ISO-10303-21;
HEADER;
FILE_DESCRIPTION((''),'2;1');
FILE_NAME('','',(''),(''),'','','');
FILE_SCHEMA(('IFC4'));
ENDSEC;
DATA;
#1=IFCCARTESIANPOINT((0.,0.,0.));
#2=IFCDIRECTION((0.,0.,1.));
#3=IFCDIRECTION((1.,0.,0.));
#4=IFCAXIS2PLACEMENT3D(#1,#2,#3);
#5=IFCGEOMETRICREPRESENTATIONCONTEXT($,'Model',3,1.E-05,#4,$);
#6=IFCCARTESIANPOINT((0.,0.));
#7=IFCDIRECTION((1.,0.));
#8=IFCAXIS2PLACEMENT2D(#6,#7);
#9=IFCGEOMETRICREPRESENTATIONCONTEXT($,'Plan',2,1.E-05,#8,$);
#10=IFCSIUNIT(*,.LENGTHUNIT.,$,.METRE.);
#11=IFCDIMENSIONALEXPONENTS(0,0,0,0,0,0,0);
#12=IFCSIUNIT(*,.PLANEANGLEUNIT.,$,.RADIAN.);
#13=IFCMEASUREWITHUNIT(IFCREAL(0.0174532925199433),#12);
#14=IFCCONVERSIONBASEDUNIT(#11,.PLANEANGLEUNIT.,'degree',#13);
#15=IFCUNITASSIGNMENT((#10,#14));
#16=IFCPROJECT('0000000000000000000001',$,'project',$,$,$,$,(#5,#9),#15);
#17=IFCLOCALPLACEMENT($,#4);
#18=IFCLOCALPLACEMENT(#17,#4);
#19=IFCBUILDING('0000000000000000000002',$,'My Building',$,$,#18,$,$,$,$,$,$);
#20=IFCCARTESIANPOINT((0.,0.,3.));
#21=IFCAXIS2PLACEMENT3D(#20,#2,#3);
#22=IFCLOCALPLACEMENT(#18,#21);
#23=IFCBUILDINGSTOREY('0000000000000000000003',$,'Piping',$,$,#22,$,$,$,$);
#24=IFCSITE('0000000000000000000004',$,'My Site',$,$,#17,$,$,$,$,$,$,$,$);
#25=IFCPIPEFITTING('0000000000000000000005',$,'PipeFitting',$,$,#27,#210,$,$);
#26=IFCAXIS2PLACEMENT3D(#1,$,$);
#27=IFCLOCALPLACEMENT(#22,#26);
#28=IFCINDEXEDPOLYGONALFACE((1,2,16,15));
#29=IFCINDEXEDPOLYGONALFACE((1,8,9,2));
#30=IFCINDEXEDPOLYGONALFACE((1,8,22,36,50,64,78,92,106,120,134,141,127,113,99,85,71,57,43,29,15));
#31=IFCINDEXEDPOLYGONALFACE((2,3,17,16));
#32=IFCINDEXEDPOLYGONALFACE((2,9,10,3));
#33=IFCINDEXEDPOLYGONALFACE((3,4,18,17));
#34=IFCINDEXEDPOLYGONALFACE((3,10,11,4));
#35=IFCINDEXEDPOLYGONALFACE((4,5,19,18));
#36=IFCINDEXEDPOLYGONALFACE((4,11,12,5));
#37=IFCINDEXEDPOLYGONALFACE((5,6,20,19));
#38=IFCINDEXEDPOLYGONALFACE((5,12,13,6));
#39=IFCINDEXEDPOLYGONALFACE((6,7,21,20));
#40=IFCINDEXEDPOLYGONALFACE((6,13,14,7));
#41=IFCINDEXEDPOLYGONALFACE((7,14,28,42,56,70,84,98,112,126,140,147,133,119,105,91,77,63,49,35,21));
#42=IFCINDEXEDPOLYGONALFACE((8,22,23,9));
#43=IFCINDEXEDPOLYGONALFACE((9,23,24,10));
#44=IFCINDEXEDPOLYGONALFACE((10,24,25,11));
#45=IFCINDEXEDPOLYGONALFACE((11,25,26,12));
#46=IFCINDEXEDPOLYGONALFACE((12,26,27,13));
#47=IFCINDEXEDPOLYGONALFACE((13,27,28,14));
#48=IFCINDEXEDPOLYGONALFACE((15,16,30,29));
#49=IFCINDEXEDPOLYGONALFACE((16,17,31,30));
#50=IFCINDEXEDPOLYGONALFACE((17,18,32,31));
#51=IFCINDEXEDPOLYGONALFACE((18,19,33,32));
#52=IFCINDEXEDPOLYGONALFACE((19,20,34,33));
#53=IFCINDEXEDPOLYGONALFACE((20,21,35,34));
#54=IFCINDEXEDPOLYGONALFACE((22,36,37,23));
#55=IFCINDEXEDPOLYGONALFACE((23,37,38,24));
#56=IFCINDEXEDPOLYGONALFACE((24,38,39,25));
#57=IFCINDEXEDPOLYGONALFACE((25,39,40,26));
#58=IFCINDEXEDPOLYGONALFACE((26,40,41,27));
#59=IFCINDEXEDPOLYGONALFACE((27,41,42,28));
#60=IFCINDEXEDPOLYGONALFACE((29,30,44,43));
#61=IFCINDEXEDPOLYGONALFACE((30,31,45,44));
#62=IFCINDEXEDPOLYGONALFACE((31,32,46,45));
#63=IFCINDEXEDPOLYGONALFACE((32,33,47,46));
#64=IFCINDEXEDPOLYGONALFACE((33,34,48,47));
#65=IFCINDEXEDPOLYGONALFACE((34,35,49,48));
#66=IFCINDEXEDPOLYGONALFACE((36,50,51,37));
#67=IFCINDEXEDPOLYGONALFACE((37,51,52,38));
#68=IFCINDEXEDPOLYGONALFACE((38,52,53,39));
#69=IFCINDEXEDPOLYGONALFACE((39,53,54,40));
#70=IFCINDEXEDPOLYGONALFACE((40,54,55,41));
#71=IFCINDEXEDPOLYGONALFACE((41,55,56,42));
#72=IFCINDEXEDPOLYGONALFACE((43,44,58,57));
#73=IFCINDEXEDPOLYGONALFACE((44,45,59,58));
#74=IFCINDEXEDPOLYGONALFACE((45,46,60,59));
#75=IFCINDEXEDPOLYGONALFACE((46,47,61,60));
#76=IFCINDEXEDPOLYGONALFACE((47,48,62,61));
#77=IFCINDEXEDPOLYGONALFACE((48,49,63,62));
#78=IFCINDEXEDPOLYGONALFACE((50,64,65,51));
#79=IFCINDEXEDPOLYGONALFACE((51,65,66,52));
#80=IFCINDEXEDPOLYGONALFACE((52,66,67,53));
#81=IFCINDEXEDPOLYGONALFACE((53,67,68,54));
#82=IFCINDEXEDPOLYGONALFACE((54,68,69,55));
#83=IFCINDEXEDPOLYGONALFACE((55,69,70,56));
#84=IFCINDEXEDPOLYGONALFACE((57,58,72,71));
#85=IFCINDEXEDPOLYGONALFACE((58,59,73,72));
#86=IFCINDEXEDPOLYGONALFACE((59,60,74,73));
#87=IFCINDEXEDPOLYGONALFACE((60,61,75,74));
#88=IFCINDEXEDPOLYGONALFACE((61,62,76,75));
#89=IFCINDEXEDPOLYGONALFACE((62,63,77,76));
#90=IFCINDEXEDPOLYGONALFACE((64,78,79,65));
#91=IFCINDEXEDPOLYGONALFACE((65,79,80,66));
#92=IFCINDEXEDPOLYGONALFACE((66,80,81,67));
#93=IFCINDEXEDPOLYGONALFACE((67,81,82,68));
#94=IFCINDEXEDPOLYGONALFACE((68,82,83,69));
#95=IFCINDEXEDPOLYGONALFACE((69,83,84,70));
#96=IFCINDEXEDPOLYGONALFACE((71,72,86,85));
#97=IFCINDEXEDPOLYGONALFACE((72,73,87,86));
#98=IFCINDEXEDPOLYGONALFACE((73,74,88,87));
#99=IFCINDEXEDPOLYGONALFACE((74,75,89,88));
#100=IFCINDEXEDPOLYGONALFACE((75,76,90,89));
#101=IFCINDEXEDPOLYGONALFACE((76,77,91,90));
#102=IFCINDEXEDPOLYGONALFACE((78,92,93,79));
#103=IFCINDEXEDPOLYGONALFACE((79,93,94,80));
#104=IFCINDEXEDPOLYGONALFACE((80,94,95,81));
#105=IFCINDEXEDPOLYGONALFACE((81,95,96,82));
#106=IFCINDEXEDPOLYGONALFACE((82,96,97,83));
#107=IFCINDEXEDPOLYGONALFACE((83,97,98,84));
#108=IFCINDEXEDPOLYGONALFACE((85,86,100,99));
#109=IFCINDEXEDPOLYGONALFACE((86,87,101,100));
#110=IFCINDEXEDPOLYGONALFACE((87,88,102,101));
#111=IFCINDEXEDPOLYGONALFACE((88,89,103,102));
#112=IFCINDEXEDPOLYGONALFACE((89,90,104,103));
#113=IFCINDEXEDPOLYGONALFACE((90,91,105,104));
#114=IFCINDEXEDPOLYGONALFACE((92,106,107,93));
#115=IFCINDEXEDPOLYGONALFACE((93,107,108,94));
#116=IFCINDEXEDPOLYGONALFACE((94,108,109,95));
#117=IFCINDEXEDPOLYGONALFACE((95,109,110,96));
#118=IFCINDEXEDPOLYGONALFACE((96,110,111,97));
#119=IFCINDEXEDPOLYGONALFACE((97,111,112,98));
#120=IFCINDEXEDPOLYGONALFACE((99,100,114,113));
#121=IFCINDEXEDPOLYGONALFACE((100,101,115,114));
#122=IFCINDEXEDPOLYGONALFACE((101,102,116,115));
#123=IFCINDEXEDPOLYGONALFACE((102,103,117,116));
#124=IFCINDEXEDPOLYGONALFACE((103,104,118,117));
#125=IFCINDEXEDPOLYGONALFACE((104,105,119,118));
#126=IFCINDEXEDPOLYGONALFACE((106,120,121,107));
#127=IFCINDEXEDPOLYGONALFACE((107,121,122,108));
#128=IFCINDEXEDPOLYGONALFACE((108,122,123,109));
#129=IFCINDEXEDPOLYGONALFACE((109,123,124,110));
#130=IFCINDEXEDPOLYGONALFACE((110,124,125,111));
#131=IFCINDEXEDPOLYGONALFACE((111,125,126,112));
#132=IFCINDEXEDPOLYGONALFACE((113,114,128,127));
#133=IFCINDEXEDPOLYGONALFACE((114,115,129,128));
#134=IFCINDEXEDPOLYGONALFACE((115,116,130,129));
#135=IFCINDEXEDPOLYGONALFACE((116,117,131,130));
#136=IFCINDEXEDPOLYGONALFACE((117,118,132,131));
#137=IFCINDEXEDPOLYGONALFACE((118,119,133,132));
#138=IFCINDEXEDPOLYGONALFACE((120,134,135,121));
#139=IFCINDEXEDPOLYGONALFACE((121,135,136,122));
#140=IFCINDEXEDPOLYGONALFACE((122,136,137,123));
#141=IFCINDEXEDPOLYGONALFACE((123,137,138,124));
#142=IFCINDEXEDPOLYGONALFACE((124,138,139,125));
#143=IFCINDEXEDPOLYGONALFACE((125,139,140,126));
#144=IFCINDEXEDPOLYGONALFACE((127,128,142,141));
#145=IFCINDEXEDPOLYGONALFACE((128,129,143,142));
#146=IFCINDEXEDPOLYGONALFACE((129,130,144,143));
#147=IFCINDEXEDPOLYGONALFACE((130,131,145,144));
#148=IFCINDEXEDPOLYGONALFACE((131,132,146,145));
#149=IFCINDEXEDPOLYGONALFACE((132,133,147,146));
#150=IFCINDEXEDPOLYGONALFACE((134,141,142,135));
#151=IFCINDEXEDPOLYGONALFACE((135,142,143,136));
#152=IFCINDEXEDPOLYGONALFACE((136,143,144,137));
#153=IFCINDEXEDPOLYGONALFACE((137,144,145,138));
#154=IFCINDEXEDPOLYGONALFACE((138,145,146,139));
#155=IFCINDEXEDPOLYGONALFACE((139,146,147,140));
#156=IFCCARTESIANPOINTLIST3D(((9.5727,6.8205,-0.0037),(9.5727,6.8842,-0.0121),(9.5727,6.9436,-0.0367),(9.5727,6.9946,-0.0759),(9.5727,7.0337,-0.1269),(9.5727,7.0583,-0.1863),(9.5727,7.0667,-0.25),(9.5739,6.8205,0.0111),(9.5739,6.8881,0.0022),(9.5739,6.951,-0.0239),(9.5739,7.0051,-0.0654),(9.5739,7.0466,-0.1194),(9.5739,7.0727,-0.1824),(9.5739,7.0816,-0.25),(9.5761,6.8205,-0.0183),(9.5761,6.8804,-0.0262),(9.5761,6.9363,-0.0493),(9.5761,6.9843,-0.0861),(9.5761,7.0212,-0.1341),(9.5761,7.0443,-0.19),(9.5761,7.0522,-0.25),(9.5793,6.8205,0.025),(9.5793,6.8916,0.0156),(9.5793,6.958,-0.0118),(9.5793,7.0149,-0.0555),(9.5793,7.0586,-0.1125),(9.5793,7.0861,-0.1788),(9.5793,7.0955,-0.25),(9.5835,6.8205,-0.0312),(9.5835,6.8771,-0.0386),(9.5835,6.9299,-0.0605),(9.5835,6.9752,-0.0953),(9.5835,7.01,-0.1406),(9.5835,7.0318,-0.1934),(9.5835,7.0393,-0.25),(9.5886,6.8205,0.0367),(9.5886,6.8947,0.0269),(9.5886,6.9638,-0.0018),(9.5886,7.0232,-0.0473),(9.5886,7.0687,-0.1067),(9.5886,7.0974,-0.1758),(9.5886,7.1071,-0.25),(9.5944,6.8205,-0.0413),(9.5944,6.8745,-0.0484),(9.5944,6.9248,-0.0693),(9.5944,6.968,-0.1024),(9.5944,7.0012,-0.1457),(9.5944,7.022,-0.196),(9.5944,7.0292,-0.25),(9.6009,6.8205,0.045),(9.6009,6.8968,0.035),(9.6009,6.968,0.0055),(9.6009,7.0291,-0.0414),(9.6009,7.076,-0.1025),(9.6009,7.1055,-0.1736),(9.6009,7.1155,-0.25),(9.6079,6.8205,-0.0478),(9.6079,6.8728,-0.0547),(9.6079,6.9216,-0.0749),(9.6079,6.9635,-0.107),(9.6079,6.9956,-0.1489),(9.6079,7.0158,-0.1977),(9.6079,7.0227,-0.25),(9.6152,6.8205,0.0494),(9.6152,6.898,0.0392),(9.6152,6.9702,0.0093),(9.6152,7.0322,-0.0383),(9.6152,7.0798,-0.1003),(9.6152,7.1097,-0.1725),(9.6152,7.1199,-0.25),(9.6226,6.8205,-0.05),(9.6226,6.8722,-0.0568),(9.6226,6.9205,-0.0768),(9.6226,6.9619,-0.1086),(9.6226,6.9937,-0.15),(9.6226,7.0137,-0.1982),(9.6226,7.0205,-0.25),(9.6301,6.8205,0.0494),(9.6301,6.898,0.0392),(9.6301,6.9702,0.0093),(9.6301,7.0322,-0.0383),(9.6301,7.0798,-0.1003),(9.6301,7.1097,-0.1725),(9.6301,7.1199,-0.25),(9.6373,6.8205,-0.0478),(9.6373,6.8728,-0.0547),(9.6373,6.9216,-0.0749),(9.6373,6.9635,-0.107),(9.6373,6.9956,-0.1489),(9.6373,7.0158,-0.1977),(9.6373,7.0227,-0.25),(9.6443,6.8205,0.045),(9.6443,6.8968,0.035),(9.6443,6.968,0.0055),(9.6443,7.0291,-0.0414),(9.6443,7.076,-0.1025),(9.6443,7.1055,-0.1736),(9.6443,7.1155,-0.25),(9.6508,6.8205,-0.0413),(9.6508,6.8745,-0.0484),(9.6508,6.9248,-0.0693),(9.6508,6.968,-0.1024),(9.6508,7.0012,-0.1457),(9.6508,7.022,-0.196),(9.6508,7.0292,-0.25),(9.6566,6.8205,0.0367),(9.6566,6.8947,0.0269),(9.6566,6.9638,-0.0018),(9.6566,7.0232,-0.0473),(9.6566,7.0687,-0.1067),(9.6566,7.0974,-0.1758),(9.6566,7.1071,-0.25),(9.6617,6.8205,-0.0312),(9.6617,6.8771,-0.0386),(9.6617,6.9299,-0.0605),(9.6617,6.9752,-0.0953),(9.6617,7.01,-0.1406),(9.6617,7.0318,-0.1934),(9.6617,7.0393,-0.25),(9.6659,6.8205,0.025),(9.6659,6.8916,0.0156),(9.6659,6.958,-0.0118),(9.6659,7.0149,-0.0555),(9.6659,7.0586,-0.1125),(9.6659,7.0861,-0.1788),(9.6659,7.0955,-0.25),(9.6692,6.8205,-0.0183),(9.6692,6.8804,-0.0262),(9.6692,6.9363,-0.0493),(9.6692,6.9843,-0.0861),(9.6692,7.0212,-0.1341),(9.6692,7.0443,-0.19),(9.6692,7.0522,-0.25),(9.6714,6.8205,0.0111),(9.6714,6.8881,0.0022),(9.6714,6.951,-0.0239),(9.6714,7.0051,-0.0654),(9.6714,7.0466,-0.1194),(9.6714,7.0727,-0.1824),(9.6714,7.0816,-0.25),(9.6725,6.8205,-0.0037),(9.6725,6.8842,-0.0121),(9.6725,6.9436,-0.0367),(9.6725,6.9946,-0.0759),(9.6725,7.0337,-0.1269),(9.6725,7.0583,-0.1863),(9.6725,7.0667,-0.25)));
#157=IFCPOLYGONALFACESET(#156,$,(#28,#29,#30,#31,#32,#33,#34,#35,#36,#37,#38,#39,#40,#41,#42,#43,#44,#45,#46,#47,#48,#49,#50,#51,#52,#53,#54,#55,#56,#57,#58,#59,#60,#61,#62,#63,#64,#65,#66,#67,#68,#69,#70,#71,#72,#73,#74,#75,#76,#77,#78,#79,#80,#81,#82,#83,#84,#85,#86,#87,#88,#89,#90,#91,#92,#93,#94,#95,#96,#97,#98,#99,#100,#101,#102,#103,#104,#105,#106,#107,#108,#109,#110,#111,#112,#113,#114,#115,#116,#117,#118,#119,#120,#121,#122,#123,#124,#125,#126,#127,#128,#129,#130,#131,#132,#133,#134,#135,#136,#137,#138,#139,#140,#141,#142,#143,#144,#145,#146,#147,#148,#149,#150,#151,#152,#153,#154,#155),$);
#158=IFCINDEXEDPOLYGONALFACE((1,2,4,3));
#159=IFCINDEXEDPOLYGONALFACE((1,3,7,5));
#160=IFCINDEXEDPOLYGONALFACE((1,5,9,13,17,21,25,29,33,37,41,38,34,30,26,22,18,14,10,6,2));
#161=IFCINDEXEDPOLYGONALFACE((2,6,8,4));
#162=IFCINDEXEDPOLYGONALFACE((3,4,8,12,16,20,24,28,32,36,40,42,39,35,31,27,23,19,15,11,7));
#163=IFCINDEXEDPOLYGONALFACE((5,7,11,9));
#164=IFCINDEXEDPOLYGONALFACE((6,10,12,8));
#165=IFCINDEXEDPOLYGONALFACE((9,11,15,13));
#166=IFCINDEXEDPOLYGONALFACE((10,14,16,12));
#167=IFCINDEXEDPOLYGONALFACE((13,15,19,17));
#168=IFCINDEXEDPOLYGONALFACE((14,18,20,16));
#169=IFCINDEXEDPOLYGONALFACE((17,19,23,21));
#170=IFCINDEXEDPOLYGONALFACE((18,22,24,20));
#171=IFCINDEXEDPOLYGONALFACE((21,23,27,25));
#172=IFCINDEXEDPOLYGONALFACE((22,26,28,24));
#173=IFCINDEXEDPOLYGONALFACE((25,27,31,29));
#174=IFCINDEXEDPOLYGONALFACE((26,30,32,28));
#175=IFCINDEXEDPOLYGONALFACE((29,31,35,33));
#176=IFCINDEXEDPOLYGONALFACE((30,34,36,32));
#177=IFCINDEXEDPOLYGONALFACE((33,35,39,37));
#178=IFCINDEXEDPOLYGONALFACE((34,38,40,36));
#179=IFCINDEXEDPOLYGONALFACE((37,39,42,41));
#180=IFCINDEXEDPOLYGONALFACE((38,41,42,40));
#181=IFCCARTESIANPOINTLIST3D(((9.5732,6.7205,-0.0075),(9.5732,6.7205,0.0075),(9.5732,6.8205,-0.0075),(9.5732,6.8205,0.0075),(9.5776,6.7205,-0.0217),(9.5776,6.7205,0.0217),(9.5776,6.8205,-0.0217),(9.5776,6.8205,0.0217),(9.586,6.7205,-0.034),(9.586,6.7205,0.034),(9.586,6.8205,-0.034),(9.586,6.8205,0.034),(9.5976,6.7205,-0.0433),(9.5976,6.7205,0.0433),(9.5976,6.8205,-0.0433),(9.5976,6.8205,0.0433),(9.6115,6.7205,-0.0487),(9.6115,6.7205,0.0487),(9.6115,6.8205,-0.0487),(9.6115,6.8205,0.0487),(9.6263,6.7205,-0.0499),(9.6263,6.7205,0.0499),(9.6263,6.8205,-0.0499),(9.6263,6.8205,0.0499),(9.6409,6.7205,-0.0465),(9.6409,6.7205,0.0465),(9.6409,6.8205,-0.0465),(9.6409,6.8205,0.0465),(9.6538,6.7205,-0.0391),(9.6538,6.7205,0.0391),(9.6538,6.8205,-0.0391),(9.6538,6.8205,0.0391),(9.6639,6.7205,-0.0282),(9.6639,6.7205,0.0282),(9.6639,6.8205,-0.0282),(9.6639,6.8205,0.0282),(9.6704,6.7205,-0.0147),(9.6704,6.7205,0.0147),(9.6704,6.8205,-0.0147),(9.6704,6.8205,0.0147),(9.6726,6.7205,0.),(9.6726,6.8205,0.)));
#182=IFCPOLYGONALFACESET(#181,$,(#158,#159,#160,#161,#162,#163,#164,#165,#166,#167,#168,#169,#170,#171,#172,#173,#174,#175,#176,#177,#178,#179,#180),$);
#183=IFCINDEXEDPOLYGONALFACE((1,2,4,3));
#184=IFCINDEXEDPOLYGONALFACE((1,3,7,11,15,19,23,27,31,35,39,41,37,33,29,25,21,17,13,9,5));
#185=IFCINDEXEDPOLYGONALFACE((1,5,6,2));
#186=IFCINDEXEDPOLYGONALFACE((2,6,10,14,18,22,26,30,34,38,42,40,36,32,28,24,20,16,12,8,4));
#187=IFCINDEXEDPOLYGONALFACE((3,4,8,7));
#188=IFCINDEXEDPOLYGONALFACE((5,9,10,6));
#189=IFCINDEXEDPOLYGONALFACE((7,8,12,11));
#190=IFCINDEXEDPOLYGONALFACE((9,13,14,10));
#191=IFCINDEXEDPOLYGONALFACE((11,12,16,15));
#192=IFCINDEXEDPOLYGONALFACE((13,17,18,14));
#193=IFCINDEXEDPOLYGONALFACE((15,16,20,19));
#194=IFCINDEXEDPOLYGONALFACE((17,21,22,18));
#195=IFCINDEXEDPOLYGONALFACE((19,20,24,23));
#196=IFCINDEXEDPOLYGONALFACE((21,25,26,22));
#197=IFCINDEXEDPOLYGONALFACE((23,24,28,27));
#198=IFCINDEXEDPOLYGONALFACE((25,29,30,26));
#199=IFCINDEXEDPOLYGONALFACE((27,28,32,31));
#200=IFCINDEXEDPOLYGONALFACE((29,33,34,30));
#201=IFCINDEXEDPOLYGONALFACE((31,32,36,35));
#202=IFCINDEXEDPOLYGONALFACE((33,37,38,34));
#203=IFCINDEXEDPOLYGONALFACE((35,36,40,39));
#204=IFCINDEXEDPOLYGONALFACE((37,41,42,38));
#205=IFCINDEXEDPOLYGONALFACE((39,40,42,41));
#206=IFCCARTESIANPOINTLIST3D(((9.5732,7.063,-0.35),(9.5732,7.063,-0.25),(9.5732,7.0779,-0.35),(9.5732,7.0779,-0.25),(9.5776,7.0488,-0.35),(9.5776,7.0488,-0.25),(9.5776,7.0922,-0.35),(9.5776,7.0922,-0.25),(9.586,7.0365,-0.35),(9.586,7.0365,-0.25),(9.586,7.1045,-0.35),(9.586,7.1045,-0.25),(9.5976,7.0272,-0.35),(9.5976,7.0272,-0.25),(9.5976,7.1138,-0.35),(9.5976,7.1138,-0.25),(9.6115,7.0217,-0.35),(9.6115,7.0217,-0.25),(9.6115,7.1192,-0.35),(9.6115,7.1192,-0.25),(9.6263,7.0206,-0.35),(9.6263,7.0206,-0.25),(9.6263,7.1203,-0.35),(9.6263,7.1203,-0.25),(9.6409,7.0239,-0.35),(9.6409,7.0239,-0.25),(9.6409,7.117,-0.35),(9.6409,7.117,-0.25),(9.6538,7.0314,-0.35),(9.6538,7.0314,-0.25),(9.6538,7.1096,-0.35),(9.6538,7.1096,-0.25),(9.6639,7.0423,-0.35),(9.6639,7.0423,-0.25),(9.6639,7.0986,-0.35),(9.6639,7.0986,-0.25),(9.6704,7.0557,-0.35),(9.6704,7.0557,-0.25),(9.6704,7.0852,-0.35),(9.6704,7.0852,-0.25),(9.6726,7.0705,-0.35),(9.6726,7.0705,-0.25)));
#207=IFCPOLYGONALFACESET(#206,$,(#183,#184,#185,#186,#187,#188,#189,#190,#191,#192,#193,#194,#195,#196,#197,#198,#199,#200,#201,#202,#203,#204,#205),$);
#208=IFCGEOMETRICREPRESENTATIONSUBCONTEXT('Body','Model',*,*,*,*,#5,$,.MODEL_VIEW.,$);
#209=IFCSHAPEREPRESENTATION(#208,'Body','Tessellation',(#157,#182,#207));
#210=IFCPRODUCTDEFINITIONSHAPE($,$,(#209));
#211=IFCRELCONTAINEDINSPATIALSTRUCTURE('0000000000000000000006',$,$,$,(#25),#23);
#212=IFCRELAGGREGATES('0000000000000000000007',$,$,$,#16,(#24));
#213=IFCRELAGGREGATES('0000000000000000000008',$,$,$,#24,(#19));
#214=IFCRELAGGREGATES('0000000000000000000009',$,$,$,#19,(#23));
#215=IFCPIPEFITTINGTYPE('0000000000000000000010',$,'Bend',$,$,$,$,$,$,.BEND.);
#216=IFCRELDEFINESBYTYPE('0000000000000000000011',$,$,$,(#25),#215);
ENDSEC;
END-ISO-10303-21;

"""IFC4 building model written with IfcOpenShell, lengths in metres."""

from ifc_helpers import new_model, entity, si_unit, converted_unit, frame, origin_with_axes, origin_2d_with_axis, place, context, subcontext, project, spatial, circle, extrude, source, transform, mapped, type_object, type_shapes, element, save


model = new_model("IFC4")

# Units and contexts
model_context = context("Model", 3, precision=1e-05, world=origin_with_axes())
plan_context = context("Plan", 2, precision=1e-05, world=origin_2d_with_axis())
body_context = subcontext(model_context, "Body", "Model", "MODEL_VIEW")
ifc_project = project(units=[si_unit("LENGTHUNIT", "METRE"), converted_unit("PLANEANGLEUNIT", "degree", entity("IfcReal", 0.0174532925199433), si_unit("PLANEANGLEUNIT", "RADIAN"), dimensions=[0, 0, 0, 0, 0, 0, 0])], contexts=[model_context, plan_context])

# Site, building, storey
site_placement = place(None, origin_with_axes())
site = spatial("IfcSite", under=ifc_project, at=site_placement, Name="My Site")
building_placement = place(site_placement, origin_with_axes())
building = spatial("IfcBuilding", under=site, at=building_placement, Name="My Building")
storey_placement = place(building_placement, frame((0.0, 0.0, 3.0), z_axis=(0.0, 0.0, 1.0), x_axis=(1.0, 0.0, 0.0)))
storey = spatial("IfcBuildingStorey", under=building, at=storey_placement, Name="Piping")

# Pipe fitting
pipe_fitting_type = type_object("IfcPipeFittingType", Name="Bend", PredefinedType="BEND")
shared_shape = source(origin_with_axes(), body_context, "Body", "SolidModel", [
    entity("IfcSweptDiskSolid", entity("IfcIndexedPolyCurve", entity("IfcCartesianPointList3D", [[0.0, 0.0, -0.1], [0.0, -0.0732, -0.2768], [0.0, -0.25, -0.35]]), [entity("IfcArcIndex", [1, 2, 3])]), 0.05),
    extrude(circle(Radius=0.05), origin_with_axes(), (0.0, 0.0, -1.0), 0.1),
    extrude(circle(Radius=0.05), frame((0.0, -0.25, -0.35), z_axis=(0.0, -1.0, 0.0), x_axis=(1.0, 0.0, 0.0)), (0.0, 0.0, 1.0), 0.1),
])
type_shapes(pipe_fitting_type, [shared_shape])
for number, where, z_axis, x_axis, name in (
    (1, (9.6226, 6.7205, 0.0), (0.0, -1.0, 0.0), (1.0, 0.0, 0.0), "PipeFitting"),
):
    element("IfcPipeFitting", number, at=place(storey_placement, frame(where, z_axis=z_axis, x_axis=x_axis)), inside=storey, type_object=pipe_fitting_type, Name=name, context=body_context, shape_type="MappedRepresentation", body=[
        mapped(shared_shape, transform((0.0, 0.0, 0.0), x_axis=(1.0, 0.0, 0.0), y_axis=(0.0, 1.0, 0.0), z_axis=(0.0, 0.0, 1.0), scale=1.0)),
    ])

save(model, "model.ifc")
